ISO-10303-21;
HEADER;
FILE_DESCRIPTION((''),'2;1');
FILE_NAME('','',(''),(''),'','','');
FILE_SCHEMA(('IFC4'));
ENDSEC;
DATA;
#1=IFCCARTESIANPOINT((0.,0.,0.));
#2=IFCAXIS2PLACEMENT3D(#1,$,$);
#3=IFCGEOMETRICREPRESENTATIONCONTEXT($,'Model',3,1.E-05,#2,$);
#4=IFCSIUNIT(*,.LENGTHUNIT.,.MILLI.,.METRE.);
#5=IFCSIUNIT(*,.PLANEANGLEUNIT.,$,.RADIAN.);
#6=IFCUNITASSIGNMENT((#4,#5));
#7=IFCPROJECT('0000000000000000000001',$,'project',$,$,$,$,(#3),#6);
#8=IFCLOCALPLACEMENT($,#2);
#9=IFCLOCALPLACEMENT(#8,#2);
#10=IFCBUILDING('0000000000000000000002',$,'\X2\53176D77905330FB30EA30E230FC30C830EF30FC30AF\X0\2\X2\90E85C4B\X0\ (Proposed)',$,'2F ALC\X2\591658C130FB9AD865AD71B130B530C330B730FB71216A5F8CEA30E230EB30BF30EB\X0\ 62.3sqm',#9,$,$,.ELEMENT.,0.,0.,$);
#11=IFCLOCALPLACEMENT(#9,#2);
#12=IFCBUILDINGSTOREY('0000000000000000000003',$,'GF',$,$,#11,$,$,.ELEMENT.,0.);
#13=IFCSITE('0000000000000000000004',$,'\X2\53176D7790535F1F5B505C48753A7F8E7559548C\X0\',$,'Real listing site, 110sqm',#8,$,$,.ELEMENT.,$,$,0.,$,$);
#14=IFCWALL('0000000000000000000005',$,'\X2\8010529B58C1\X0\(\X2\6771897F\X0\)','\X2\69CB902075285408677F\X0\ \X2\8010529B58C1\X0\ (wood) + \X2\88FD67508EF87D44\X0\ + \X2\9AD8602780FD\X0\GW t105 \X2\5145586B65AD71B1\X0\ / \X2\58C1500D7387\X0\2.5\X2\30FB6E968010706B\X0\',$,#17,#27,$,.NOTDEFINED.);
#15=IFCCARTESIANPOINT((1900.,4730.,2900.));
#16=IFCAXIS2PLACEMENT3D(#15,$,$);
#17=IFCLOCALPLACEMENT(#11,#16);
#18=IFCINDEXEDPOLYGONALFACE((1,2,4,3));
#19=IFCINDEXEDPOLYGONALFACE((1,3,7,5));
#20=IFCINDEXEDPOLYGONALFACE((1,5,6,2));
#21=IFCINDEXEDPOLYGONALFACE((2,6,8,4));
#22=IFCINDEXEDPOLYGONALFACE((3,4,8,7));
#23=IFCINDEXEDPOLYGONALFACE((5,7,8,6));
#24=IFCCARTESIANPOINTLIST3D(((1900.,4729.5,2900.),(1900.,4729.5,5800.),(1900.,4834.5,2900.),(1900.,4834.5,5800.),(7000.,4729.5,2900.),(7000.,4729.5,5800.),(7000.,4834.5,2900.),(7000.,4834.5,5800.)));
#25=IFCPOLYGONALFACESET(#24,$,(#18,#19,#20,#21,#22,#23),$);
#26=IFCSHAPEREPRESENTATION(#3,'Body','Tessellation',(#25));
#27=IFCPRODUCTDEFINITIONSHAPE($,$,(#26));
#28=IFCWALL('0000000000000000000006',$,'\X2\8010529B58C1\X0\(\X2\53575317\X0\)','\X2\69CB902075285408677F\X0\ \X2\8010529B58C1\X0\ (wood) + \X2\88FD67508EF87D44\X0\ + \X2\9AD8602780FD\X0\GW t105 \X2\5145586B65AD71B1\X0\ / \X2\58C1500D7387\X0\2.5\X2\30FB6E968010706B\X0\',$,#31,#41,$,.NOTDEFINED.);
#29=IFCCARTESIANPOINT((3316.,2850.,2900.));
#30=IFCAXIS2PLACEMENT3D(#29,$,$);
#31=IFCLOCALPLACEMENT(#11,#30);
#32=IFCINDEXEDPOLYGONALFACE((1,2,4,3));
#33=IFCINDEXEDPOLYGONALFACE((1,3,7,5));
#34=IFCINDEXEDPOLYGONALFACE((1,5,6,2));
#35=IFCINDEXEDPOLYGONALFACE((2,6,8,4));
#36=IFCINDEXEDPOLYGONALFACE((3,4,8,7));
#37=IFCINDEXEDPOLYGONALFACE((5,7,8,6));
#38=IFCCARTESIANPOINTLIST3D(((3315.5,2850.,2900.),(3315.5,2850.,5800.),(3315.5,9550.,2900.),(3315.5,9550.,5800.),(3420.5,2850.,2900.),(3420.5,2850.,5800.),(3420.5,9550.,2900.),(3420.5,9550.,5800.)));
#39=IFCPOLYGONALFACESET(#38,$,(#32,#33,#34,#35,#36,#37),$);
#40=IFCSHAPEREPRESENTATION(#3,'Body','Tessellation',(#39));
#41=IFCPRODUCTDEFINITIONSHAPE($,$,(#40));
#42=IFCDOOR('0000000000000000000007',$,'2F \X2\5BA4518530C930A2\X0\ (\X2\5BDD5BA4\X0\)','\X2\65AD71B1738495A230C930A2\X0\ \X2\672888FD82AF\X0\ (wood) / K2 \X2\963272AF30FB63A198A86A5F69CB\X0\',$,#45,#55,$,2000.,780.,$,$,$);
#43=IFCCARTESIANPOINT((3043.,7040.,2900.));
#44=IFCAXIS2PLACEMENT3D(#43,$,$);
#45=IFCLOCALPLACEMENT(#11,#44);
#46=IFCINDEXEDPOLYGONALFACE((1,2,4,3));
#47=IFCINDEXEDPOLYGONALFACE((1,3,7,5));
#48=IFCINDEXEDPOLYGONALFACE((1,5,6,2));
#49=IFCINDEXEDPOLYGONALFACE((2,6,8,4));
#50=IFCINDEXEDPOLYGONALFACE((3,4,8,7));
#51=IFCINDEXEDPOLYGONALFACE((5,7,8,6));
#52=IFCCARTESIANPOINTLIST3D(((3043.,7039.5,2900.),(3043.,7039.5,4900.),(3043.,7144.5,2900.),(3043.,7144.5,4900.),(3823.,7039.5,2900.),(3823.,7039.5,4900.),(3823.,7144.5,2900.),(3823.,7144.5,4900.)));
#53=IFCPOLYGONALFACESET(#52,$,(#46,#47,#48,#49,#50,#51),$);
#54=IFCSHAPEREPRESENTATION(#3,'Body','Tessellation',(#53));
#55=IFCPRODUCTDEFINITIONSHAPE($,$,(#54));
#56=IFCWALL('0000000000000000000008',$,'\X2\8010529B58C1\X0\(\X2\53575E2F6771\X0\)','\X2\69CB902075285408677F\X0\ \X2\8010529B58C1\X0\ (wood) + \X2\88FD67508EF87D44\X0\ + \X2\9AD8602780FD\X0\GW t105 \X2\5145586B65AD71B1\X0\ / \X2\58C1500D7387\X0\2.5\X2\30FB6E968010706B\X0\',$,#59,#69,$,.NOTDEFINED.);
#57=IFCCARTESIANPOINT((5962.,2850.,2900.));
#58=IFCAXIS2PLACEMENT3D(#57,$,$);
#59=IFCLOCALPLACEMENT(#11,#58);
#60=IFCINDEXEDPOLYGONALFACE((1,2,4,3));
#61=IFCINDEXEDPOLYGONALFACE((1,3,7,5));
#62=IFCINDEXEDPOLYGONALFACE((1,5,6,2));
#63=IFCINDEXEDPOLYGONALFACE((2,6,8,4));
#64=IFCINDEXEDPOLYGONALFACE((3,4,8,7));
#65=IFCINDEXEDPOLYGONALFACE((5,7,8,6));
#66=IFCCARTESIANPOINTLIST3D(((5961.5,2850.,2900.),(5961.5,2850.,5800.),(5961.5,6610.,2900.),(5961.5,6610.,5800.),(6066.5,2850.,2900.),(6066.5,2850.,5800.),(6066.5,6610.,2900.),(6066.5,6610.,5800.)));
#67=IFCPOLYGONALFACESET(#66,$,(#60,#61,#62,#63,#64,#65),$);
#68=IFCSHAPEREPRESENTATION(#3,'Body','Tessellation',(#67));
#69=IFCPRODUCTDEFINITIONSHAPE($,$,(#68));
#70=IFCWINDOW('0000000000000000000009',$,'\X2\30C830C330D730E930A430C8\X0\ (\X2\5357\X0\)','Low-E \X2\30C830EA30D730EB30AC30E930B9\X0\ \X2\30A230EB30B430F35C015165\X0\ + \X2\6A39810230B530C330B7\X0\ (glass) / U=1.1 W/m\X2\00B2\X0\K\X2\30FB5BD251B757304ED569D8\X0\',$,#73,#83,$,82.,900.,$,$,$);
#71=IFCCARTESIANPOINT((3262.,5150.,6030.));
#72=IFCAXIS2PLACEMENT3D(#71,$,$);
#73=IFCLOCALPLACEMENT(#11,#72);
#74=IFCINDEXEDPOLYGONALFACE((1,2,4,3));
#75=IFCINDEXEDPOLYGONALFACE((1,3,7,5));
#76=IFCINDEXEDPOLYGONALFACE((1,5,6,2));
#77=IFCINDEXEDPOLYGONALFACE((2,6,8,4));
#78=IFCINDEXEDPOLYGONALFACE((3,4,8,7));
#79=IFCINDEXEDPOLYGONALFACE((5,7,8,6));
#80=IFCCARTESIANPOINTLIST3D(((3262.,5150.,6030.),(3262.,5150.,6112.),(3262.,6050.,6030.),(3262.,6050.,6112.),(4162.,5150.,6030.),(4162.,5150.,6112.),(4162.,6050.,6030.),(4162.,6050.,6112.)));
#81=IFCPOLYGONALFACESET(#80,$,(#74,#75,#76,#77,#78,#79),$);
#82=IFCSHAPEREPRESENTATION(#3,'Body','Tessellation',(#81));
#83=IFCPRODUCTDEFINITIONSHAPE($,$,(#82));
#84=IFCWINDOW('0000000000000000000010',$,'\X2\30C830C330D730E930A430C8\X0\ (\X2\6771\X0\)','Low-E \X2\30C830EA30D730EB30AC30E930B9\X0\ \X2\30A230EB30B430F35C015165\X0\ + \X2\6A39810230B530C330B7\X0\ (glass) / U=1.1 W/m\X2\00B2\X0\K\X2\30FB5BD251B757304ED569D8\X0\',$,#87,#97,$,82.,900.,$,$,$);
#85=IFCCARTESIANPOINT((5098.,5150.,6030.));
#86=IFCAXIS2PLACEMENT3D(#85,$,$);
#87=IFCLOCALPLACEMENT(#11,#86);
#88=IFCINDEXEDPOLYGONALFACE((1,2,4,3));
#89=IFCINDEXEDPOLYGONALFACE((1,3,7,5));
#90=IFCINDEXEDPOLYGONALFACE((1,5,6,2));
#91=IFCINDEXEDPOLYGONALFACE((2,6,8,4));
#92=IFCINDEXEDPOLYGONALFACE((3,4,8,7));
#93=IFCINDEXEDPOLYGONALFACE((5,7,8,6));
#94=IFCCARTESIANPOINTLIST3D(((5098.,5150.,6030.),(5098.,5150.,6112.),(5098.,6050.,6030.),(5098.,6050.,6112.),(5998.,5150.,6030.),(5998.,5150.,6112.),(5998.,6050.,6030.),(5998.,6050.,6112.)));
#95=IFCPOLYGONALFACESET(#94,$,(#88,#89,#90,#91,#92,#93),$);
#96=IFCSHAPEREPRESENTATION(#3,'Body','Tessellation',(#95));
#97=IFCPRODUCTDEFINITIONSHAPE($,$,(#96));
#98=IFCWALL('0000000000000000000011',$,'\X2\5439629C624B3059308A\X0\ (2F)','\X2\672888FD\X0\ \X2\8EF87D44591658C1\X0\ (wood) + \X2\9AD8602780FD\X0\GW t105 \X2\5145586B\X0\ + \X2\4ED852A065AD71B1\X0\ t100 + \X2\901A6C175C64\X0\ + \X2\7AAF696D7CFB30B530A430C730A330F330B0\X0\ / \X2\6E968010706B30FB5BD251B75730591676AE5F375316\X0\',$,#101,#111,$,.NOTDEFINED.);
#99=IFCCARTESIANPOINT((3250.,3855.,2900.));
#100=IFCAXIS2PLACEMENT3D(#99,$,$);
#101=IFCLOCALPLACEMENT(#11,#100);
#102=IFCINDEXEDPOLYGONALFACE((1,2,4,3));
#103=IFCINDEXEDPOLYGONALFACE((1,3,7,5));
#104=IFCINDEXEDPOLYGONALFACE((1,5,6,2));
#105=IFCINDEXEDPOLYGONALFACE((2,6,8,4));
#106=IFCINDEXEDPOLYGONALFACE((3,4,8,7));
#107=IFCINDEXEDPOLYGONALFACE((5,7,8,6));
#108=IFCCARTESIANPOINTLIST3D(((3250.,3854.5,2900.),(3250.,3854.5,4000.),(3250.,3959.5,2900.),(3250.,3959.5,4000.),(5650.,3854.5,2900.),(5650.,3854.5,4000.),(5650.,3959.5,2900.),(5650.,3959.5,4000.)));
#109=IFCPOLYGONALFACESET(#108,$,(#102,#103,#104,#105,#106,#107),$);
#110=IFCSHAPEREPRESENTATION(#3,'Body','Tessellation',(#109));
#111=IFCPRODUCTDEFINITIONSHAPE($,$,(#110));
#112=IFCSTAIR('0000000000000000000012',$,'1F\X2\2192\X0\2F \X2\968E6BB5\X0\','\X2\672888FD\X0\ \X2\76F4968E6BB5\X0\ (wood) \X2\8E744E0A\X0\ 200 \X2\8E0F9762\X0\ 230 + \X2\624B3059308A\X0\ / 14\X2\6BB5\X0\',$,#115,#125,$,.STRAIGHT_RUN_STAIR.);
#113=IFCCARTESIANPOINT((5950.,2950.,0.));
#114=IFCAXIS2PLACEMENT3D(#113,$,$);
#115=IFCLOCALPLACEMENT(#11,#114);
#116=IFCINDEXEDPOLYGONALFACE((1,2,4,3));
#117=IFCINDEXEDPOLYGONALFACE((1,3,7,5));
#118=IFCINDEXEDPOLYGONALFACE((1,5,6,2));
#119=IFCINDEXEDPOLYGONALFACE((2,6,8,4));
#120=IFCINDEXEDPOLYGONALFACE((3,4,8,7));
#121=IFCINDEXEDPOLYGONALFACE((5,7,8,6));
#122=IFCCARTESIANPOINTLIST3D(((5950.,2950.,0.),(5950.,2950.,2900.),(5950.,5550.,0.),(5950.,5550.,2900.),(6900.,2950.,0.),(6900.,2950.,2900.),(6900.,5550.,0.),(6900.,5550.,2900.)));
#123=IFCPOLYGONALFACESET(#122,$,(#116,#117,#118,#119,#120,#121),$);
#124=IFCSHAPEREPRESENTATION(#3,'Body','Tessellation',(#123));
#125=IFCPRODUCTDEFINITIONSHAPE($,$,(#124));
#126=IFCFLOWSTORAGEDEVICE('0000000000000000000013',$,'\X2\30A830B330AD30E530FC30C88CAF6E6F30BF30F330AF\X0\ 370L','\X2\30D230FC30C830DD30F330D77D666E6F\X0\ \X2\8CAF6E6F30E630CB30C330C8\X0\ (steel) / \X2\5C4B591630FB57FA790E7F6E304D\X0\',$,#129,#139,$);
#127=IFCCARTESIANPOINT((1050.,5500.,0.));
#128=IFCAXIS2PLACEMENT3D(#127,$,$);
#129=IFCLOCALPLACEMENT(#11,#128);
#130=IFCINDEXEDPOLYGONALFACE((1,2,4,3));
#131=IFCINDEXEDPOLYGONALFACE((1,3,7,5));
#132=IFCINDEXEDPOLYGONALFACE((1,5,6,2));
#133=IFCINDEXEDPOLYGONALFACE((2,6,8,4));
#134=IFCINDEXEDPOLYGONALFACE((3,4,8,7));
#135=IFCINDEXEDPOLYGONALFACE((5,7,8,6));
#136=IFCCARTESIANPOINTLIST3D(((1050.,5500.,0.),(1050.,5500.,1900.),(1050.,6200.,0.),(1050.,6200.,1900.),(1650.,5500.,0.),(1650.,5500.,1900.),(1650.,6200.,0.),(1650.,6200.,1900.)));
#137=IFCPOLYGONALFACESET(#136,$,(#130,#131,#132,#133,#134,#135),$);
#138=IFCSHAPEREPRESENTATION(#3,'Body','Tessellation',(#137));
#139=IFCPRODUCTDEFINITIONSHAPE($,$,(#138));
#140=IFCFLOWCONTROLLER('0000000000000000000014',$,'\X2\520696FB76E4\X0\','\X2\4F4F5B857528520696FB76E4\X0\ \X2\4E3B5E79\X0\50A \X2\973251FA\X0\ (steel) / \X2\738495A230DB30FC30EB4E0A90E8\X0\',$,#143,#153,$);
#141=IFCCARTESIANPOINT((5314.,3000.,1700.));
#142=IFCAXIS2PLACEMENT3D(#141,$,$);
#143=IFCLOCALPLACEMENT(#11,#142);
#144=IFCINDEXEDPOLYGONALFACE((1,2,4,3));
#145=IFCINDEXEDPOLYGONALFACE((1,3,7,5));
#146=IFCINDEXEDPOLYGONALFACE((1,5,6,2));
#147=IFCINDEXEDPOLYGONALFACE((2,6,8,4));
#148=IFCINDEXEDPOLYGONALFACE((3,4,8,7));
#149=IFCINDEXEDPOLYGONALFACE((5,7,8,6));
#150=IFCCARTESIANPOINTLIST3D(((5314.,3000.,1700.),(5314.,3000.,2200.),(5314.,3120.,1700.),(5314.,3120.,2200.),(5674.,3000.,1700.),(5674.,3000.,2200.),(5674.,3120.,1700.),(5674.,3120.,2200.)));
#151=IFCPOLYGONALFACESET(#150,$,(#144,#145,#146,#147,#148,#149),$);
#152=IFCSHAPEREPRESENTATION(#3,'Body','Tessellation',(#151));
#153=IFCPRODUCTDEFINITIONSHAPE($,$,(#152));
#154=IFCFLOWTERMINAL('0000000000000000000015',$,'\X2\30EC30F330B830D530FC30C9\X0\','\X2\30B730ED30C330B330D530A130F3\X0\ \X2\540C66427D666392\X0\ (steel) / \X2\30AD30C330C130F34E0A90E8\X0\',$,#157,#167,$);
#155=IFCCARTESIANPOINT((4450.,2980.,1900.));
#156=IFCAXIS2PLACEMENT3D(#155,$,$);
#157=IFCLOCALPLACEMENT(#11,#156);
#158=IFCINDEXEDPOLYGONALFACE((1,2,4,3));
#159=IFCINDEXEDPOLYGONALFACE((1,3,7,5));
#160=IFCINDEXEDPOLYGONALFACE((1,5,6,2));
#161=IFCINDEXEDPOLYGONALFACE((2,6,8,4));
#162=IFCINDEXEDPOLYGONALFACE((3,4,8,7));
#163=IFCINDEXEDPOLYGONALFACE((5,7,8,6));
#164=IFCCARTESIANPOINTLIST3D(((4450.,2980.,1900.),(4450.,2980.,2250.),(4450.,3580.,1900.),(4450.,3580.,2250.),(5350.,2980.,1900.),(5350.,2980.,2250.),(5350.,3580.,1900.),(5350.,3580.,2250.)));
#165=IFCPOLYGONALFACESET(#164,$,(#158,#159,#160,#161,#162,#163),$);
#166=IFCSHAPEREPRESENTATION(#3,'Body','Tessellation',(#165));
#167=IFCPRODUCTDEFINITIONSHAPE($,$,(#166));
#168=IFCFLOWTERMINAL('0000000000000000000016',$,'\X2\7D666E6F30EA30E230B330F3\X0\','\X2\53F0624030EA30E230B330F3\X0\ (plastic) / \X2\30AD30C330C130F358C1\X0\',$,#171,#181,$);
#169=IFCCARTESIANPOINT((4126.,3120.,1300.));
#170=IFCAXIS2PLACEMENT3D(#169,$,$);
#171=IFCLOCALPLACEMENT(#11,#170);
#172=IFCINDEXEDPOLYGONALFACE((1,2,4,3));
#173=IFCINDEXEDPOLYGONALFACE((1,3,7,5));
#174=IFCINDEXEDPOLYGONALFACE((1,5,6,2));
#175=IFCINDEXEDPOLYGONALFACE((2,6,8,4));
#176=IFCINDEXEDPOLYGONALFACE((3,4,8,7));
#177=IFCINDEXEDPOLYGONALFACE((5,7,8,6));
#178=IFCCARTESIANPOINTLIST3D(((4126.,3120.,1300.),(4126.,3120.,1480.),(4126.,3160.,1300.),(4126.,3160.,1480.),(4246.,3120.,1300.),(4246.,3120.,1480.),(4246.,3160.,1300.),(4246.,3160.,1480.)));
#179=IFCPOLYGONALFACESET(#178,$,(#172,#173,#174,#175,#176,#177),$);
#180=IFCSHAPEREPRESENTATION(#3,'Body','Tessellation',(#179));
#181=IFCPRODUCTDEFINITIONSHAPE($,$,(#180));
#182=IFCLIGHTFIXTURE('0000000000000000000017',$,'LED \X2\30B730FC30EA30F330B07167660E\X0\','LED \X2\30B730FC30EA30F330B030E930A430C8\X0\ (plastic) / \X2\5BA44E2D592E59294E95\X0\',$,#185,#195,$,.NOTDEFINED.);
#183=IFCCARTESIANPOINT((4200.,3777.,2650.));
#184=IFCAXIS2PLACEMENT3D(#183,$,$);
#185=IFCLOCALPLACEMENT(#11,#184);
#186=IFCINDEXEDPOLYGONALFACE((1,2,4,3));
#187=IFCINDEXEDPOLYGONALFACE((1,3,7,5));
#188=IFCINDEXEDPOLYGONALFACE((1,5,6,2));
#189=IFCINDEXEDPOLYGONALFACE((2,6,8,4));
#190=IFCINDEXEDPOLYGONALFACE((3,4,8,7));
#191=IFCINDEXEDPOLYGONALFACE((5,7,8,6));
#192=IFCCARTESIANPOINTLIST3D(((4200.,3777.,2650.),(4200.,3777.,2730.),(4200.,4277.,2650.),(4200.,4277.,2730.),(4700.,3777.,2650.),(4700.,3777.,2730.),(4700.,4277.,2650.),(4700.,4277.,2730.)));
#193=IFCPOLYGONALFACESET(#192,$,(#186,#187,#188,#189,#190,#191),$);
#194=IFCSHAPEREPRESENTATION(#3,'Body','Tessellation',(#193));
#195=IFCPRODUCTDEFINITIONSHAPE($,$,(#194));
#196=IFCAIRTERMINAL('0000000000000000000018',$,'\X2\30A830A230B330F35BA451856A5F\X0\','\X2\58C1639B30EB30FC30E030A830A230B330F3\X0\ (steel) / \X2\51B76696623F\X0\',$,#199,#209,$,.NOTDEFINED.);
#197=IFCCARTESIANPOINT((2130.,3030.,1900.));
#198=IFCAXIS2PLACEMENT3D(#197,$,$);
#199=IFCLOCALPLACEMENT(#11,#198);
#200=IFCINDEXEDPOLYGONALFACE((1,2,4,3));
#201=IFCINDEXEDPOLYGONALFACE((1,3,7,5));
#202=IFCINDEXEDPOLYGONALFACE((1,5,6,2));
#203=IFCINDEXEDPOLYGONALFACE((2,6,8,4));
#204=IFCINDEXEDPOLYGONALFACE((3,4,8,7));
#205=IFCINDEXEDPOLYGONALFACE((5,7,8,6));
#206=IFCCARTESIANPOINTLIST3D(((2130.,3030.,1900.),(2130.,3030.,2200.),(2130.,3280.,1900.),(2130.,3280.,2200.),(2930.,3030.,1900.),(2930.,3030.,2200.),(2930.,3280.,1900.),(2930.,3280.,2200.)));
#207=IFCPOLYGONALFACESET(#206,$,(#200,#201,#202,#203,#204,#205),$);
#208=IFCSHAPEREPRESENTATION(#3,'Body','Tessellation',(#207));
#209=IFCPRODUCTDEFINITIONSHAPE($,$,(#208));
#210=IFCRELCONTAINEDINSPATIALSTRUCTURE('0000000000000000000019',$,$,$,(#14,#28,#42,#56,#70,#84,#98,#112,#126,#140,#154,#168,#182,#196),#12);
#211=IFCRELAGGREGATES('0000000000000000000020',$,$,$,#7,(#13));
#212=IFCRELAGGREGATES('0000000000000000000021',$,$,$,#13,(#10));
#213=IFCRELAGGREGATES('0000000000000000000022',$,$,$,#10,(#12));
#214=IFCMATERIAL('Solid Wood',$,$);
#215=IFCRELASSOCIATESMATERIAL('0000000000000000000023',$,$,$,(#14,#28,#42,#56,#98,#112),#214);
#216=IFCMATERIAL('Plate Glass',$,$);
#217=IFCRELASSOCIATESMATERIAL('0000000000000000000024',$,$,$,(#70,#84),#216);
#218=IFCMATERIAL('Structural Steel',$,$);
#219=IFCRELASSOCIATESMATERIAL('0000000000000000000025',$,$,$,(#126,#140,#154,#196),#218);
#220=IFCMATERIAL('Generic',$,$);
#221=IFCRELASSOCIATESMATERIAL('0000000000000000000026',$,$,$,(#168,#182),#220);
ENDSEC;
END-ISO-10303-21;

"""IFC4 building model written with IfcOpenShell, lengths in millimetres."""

from ifc_helpers import new_model, si_unit, frame, frame_2d, origin, place, context, project, spatial, rectangle, extrude, material, element, fill, save


model = new_model("IFC4")

# Units and contexts
model_context = context("Model", 3, precision=1e-05, world=origin())
ifc_project = project(units=[si_unit("LENGTHUNIT", "METRE", prefix="MILLI"), si_unit("PLANEANGLEUNIT", "RADIAN")], contexts=[model_context])

# Site, building, storey
site_placement = place(None, origin())
site = spatial("IfcSite", under=ifc_project, at=site_placement, Name="北海道弟子屈町美留和", ObjectType="Real listing site, 110sqm", CompositionType="ELEMENT", RefElevation=0.0)
building_placement = place(site_placement, origin())
building = spatial("IfcBuilding", under=site, at=building_placement, Name="北海道・リモートワーク2部屋 (Proposed)", ObjectType="2F ALC外壁・高断熱サッシ・無機質モルタル 62.3sqm", CompositionType="ELEMENT", ElevationOfRefHeight=0.0, ElevationOfTerrain=0.0)
storey_placement = place(building_placement, origin())
storey = spatial("IfcBuildingStorey", under=building, at=storey_placement, Name="GF", CompositionType="ELEMENT", Elevation=0.0)

# Shared definitions
ifc_material_1 = material(Name="Solid Wood")

# Wall
wall_1_placement = place(storey_placement, frame((1900.0, 4730.0, 2900.0)))
element("IfcWall", 1, at=wall_1_placement, inside=storey, material=ifc_material_1, Name="耐力壁(東西)", Description="構造用合板 耐力壁 (wood) + 製材軸組 + 高性能GW t105 充填断熱 / 壁倍率2.5・準耐火", PredefinedType="NOTDEFINED", context=model_context, shape_type="SweptSolid", body=[
    extrude(rectangle(XDim=5100.0, YDim=105.0, at=frame_2d((2550.0, 52.0))), frame((1900.0, 4730.0, 2900.0)), (0.0, 0.0, 1.0), 2900.0),
])

# Wall, opening, door
wall_2_placement = place(storey_placement, frame((3316.0, 2850.0, 2900.0)))
wall_2 = element("IfcWall", 2, at=wall_2_placement, inside=storey, material=ifc_material_1, Name="耐力壁(南北)", Description="構造用合板 耐力壁 (wood) + 製材軸組 + 高性能GW t105 充填断熱 / 壁倍率2.5・準耐火", PredefinedType="NOTDEFINED", context=model_context, shape_type="SweptSolid", body=[
    extrude(rectangle(XDim=105.0, YDim=6700.0, at=frame_2d((52.0, 3350.0))), frame((3316.0, 2850.0, 2900.0)), (0.0, 0.0, 1.0), 2900.0),
])
opening_placement = place(storey_placement, frame((3043.0, 7040.0, 2900.0)))
opening = element("IfcOpeningElement", 3, at=opening_placement, cuts=wall_2, PredefinedType="NOTDEFINED", context=model_context, shape_type="SweptSolid", body=[
    extrude(rectangle(XDim=780.0, YDim=105.0, at=frame_2d((390.0, 52.0))), frame((3043.0, 7040.0, 2900.0)), (0.0, 0.0, 1.0), 2000.0),
])
door_placement = place(storey_placement, frame((3043.0, 7040.0, 2900.0)))
door = element("IfcDoor", 4, at=door_placement, inside=storey, material=ifc_material_1, Name="2F 室内ドア (寝室)", Description="断熱玄関ドア 木製芯 (wood) / K2 防犯・採風機構", OverallHeight=2000.0, OverallWidth=780.0, context=model_context, shape_type="SweptSolid", body=[
    extrude(rectangle(XDim=780.0, YDim=105.0, at=frame_2d((390.0, 52.0))), frame((3043.0, 7040.0, 2900.0)), (0.0, 0.0, 1.0), 2000.0),
])
fill(opening, door)

# Wall
wall_3_placement = place(storey_placement, frame((5962.0, 2850.0, 2900.0)))
element("IfcWall", 5, at=wall_3_placement, inside=storey, material=ifc_material_1, Name="耐力壁(南帯東)", Description="構造用合板 耐力壁 (wood) + 製材軸組 + 高性能GW t105 充填断熱 / 壁倍率2.5・準耐火", PredefinedType="NOTDEFINED", context=model_context, shape_type="SweptSolid", body=[
    extrude(rectangle(XDim=105.0, YDim=3760.0, at=frame_2d((52.0, 1880.0))), frame((5962.0, 2850.0, 2900.0)), (0.0, 0.0, 1.0), 2900.0),
])

# Windows
ifc_material_2 = material(Name="Plate Glass")
window_1_placement = place(storey_placement, frame((3262.0, 5150.0, 6030.0)))
element("IfcWindow", 6, at=window_1_placement, inside=storey, material=ifc_material_2, Name="トップライト (南)", Description="Low-E トリプルガラス アルゴン封入 + 樹脂サッシ (glass) / U=1.1 W/m²K・寒冷地仕様", OverallHeight=82.0, OverallWidth=900.0, context=model_context, shape_type="SweptSolid", body=[
    extrude(rectangle(XDim=900.0, YDim=900.0, at=frame_2d((450.0, 450.0))), frame((3262.0, 5150.0, 6030.0)), (0.0, 0.0, 1.0), 82.0),
])
window_2_placement = place(storey_placement, frame((5098.0, 5150.0, 6030.0)))
element("IfcWindow", 7, at=window_2_placement, inside=storey, material=ifc_material_2, Name="トップライト (東)", Description="Low-E トリプルガラス アルゴン封入 + 樹脂サッシ (glass) / U=1.1 W/m²K・寒冷地仕様", OverallHeight=82.0, OverallWidth=900.0, context=model_context, shape_type="SweptSolid", body=[
    extrude(rectangle(XDim=900.0, YDim=900.0, at=frame_2d((450.0, 450.0))), frame((5098.0, 5150.0, 6030.0)), (0.0, 0.0, 1.0), 82.0),
])

# Wall
wall_4_placement = place(storey_placement, frame((3250.0, 3855.0, 2900.0)))
element("IfcWall", 8, at=wall_4_placement, inside=storey, material=ifc_material_1, Name="吹抜手すり (2F)", Description="木製 軸組外壁 (wood) + 高性能GW t105 充填 + 付加断熱 t100 + 通気層 + 窯業系サイディング / 準耐火・寒冷地外皮強化", PredefinedType="NOTDEFINED", context=model_context, shape_type="SweptSolid", body=[
    extrude(rectangle(XDim=2400.0, YDim=105.0, at=frame_2d((1200.0, 52.0))), frame((3250.0, 3855.0, 2900.0)), (0.0, 0.0, 1.0), 1100.0),
])

# Stair
stair_placement = place(storey_placement, frame((5950.0, 2950.0, 0.0)))
element("IfcStair", 9, at=stair_placement, inside=storey, material=ifc_material_1, Name="1F→2F 階段", Description="木製 直階段 (wood) 蹴上 200 踏面 230 + 手すり / 14段", PredefinedType="STRAIGHT_RUN_STAIR", context=model_context, shape_type="SweptSolid", body=[
    extrude(rectangle(XDim=950.0, YDim=2600.0, at=frame_2d((475.0, 1300.0))), frame((5950.0, 2950.0, 0.0)), (0.0, 0.0, 1.0), 2900.0),
])

# Flow storage device
ifc_material_3 = material(Name="Structural Steel")
flow_storage_device_placement = place(storey_placement, frame((1050.0, 5500.0, 0.0)))
element("IfcFlowStorageDevice", 10, at=flow_storage_device_placement, inside=storey, material=ifc_material_3, Name="エコキュート貯湯タンク 370L", Description="ヒートポンプ給湯 貯湯ユニット (steel) / 屋外・基礎置き", context=model_context, shape_type="SweptSolid", body=[
    extrude(rectangle(XDim=600.0, YDim=700.0, at=frame_2d((300.0, 350.0))), frame((1050.0, 5500.0, 0.0)), (0.0, 0.0, 1.0), 1900.0),
])

# Flow controller
flow_controller_placement = place(storey_placement, frame((5314.0, 3000.0, 1700.0)))
element("IfcFlowController", 11, at=flow_controller_placement, inside=storey, material=ifc_material_3, Name="分電盤", Description="住宅用分電盤 主幹50A 露出 (steel) / 玄関ホール上部", context=model_context, shape_type="SweptSolid", body=[
    extrude(rectangle(XDim=360.0, YDim=120.0, at=frame_2d((180.0, 60.0))), frame((5314.0, 3000.0, 1700.0)), (0.0, 0.0, 1.0), 500.0),
])

# Flow terminals
flow_terminal_1_placement = place(storey_placement, frame((4450.0, 2980.0, 1900.0)))
element("IfcFlowTerminal", 12, at=flow_terminal_1_placement, inside=storey, material=ifc_material_3, Name="レンジフード", Description="シロッコファン 同時給排 (steel) / キッチン上部", context=model_context, shape_type="SweptSolid", body=[
    extrude(rectangle(XDim=900.0, YDim=600.0, at=frame_2d((450.0, 300.0))), frame((4450.0, 2980.0, 1900.0)), (0.0, 0.0, 1.0), 350.0),
])
ifc_material_4 = material(Name="Generic")
flow_terminal_2_placement = place(storey_placement, frame((4126.0, 3120.0, 1300.0)))
element("IfcFlowTerminal", 13, at=flow_terminal_2_placement, inside=storey, material=ifc_material_4, Name="給湯リモコン", Description="台所リモコン (plastic) / キッチン壁", context=model_context, shape_type="SweptSolid", body=[
    extrude(rectangle(XDim=120.0, YDim=40.0, at=frame_2d((60.0, 20.0))), frame((4126.0, 3120.0, 1300.0)), (0.0, 0.0, 1.0), 180.0),
])

# Light fixture
light_fixture_1_placement = place(storey_placement, frame((4200.0, 3777.0, 2650.0)))
element("IfcLightFixture", 14, at=light_fixture_1_placement, inside=storey, material=ifc_material_4, Name="LED シーリング照明", Description="LED シーリングライト (plastic) / 室中央天井", PredefinedType="NOTDEFINED", context=model_context, shape_type="SweptSolid", body=[
    extrude(rectangle(XDim=500.0, YDim=500.0, at=frame_2d((250.0, 250.0))), frame((4200.0, 3777.0, 2650.0)), (0.0, 0.0, 1.0), 80.0),
])

# Air terminal
air_terminal_1_placement = place(storey_placement, frame((2130.0, 3030.0, 1900.0)))
element("IfcAirTerminal", 15, at=air_terminal_1_placement, inside=storey, material=ifc_material_3, Name="エアコン室内機", Description="壁掛ルームエアコン (steel) / 冷暖房", PredefinedType="NOTDEFINED", context=model_context, shape_type="SweptSolid", body=[
    extrude(rectangle(XDim=800.0, YDim=250.0, at=frame_2d((400.0, 125.0))), frame((2130.0, 3030.0, 1900.0)), (0.0, 0.0, 1.0), 300.0),
])

save(model, "model.ifc")
